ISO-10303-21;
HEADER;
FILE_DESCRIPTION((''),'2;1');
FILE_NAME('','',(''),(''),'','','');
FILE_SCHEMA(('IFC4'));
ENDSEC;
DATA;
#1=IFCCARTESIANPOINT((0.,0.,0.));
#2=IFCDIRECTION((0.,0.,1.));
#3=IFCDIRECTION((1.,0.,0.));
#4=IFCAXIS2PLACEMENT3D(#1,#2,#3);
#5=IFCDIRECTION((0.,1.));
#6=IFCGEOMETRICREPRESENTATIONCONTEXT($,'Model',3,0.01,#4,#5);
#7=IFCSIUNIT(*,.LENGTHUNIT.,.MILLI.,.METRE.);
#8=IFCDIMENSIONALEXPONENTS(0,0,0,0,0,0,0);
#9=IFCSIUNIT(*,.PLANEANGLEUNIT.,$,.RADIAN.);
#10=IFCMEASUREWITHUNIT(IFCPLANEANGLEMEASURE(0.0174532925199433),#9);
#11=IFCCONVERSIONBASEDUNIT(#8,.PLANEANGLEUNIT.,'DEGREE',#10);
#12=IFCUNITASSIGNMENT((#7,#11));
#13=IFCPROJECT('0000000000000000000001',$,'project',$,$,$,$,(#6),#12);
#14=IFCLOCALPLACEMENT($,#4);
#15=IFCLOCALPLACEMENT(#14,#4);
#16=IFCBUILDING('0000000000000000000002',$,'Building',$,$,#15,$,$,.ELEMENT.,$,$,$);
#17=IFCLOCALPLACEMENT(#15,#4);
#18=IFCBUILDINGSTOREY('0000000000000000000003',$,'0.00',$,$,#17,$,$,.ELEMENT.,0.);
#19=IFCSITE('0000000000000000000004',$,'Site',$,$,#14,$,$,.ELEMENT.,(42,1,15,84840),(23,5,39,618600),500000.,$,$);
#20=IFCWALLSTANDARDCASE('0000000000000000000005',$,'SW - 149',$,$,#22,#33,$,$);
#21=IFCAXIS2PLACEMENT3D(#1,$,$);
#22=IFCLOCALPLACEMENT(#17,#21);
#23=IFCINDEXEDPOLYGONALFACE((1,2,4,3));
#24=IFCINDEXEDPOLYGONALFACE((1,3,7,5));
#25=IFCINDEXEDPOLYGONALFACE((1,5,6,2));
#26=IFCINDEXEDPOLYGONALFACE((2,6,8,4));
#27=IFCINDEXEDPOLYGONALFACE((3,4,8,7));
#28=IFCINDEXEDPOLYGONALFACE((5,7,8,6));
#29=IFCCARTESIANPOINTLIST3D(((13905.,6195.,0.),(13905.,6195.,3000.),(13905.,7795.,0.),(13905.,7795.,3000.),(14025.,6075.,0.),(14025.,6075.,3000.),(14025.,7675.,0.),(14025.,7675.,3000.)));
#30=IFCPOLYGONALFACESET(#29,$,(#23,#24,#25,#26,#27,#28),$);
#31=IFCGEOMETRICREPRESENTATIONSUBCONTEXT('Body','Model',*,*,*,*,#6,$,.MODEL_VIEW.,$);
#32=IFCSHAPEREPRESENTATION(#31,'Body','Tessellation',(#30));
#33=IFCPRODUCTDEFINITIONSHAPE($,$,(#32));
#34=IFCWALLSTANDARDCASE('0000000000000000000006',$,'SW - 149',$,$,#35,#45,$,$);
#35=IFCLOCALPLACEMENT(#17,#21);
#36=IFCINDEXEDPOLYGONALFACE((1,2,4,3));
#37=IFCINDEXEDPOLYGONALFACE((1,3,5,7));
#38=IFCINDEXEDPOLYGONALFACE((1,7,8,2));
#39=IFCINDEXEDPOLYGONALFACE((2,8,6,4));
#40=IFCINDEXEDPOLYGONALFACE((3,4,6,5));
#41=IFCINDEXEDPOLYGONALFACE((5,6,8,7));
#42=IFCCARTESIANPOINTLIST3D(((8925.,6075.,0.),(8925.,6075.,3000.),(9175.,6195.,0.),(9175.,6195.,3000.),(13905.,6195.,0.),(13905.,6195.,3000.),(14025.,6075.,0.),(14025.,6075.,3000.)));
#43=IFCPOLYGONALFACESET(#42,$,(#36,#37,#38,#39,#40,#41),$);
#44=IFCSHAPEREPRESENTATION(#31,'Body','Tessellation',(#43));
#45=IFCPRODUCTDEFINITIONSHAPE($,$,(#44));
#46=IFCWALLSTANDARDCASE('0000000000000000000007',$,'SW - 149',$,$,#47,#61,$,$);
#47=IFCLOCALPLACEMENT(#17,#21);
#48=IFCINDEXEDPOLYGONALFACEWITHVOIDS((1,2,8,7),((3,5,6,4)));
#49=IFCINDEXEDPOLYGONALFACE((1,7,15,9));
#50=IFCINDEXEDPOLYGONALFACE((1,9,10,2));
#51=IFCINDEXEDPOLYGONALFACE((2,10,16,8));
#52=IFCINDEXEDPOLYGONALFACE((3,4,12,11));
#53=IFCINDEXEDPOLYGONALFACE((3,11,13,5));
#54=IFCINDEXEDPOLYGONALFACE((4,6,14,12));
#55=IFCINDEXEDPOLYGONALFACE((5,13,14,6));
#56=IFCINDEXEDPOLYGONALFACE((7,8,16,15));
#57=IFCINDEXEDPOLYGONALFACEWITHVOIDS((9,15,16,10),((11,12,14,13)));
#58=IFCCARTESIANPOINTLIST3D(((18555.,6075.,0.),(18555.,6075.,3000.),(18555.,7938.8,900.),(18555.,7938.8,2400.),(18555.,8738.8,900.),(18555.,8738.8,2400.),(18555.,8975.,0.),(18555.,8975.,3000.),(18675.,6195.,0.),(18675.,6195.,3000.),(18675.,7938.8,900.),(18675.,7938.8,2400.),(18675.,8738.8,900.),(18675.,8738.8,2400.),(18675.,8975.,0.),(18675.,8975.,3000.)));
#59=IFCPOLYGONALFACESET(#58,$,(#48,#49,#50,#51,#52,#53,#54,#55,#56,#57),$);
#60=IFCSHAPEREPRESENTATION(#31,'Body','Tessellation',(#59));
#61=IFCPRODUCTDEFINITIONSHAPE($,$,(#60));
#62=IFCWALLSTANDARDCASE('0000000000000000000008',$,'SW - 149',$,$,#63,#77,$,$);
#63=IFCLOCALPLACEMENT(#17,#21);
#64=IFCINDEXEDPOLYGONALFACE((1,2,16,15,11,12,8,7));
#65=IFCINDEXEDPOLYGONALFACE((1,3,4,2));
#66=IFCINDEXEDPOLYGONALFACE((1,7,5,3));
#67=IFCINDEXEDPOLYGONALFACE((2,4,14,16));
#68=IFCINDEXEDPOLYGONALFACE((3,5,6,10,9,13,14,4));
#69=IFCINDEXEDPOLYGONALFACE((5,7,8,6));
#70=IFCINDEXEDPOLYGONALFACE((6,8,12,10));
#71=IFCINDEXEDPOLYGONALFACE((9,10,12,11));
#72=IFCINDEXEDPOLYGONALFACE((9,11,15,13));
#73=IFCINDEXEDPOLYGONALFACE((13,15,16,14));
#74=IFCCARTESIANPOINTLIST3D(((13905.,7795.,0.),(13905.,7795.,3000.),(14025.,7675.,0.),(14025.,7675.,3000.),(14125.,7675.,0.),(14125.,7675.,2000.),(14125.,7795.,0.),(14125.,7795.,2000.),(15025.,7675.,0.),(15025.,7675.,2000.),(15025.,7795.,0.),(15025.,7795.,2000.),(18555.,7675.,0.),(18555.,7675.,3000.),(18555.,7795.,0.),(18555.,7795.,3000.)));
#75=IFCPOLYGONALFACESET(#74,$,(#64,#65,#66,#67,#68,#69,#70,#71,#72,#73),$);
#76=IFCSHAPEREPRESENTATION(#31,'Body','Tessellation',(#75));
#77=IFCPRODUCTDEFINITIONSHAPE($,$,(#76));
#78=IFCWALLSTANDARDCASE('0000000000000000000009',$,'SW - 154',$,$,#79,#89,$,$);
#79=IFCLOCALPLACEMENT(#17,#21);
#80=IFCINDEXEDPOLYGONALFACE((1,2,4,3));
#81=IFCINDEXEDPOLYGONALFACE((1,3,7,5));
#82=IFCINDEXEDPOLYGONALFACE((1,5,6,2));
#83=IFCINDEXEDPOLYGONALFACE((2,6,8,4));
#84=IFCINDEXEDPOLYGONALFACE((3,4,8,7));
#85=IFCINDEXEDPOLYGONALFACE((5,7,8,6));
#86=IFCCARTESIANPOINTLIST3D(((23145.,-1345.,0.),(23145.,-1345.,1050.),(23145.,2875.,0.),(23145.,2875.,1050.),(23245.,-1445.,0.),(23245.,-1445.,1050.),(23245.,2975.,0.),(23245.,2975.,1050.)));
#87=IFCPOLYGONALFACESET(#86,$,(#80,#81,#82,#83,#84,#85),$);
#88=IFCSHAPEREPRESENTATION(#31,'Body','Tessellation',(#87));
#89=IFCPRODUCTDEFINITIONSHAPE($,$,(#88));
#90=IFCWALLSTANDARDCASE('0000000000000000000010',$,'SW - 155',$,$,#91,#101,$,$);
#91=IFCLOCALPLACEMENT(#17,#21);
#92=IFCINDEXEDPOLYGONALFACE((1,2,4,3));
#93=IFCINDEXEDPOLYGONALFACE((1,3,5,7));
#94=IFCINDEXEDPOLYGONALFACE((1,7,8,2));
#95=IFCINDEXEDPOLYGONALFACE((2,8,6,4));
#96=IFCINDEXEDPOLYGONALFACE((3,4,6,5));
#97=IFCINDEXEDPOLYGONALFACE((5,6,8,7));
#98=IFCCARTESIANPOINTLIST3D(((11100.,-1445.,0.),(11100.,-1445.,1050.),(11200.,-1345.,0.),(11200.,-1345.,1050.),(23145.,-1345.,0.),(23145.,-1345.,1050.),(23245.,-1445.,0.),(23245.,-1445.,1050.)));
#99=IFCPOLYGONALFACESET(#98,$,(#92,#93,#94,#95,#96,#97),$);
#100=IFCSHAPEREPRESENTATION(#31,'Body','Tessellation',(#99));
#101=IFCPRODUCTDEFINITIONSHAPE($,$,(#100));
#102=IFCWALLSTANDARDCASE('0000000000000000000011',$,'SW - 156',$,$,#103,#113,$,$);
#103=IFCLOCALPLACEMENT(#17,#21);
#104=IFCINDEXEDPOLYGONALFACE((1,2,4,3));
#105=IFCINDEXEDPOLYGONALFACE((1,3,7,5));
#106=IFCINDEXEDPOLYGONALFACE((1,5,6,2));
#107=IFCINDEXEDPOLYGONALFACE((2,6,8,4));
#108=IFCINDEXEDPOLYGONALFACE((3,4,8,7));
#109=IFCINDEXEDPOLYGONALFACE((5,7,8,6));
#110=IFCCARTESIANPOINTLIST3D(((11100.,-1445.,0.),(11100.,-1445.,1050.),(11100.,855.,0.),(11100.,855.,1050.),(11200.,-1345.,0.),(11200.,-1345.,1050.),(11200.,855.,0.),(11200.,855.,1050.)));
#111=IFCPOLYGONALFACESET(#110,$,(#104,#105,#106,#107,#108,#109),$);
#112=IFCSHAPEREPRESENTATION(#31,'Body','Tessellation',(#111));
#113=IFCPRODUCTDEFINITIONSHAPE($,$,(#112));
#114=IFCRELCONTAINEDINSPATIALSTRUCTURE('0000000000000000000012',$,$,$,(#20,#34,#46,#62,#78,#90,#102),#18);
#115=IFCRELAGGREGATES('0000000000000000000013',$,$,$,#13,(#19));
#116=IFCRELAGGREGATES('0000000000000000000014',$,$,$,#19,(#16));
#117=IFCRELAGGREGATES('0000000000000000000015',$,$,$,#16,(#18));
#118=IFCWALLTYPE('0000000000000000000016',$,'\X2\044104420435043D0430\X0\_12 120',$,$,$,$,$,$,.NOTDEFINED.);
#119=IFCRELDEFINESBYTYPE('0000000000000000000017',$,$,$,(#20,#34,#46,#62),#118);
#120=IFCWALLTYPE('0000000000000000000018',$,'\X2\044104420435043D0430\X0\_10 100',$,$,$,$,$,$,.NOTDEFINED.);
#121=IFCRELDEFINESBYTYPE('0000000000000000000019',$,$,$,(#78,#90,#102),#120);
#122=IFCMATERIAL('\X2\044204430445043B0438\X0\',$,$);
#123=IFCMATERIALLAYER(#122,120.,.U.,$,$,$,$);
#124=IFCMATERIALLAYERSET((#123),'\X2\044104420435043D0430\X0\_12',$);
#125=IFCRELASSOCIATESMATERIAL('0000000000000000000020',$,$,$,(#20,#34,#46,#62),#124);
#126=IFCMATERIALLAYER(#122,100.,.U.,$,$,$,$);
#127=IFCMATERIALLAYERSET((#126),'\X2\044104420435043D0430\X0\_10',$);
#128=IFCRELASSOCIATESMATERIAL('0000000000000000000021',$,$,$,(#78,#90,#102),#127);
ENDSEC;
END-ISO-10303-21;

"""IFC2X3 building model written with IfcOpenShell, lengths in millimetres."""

from ifc_helpers import new_model, entity, si_unit, converted_unit, direction, frame, origin_with_axes, origin_2d_with_axis, place, context, subcontext, project, spatial, polyline, rectangle, outline, extrude, material, layer, layer_set, layer_usage, type_object, element, save


model = new_model("IFC2X3")

# Units and contexts
model_context = context("Model", 3, precision=0.01, world=origin_with_axes(), true_north=direction((0.0, 1.0)))
body_context = subcontext(model_context, "Body", "Model", "MODEL_VIEW")
ifc_project = project(units=[si_unit("LENGTHUNIT", "METRE", prefix="MILLI"), converted_unit("PLANEANGLEUNIT", "DEGREE", entity("IfcPlaneAngleMeasure", 0.0174532925199433), si_unit("PLANEANGLEUNIT", "RADIAN"), dimensions=[0, 0, 0, 0, 0, 0, 0])], contexts=[model_context])

# Site, building, storey
site_placement = place(None, origin_with_axes())
site = spatial("IfcSite", under=ifc_project, at=site_placement, Name="Site", CompositionType="ELEMENT", RefLatitude=(42, 1, 15, 84840), RefLongitude=(23, 5, 39, 618600), RefElevation=500000.0)
building_placement = place(site_placement, origin_with_axes())
building = spatial("IfcBuilding", under=site, at=building_placement, Name="Building", CompositionType="ELEMENT")
storey_placement = place(building_placement, origin_with_axes())
storey = spatial("IfcBuildingStorey", under=building, at=storey_placement, Name="0.00", CompositionType="ELEMENT", Elevation=0.0)

# Shared definitions
ifc_material_1 = material(Name="тухли")

# Shared definitions
ifc_layer_1 = layer(ifc_material_1, 120.0, ventilated="UNKNOWN")
ifc_layer_set_1 = layer_set([ifc_layer_1], Name="стена_12")
wall_type_1 = type_object("IfcWallType", Name="стена_12 120", PredefinedType="NOTDEFINED")

# Walls
ifc_layer_usage_1 = layer_usage(ifc_layer_set_1, "AXIS2", "NEGATIVE", 0.0)
wall_1_placement = place(storey_placement, frame((14025.0, 7675.0, 0.0), z_axis=(0.0, 0.0, 1.0), x_axis=(0.0, -1.0, 0.0)))
element("IfcWallStandardCase", 1, at=wall_1_placement, inside=storey, type_object=wall_type_1, material=ifc_layer_usage_1, Name="SW - 149", context=body_context, shape_type="SweptSolid", body=[
    extrude(outline(polyline([(-120.0, -120.0), (1480.0, -120.0), (1600.0, 0.0), (0.0, 0.0), (-120.0, -120.0)])), origin_with_axes(), (0.0, 0.0, 1.0), 3000.0),
])
ifc_layer_usage_2 = layer_usage(ifc_layer_set_1, "AXIS2", "NEGATIVE", 0.0)
wall_2_placement = place(storey_placement, frame((14025.0, 6075.0, 0.0), z_axis=(0.0, 0.0, 1.0), x_axis=(-1.0, 0.0, 0.0)))
element("IfcWallStandardCase", 2, at=wall_2_placement, inside=storey, type_object=wall_type_1, material=ifc_layer_usage_2, Name="SW - 149", context=body_context, shape_type="SweptSolid", body=[
    extrude(outline(polyline([(120.0, -120.0), (4850.0, -120.0), (5100.0, 0.0), (0.0, 0.0), (120.0, -120.0)])), origin_with_axes(), (0.0, 0.0, 1.0), 3000.0),
])

# Walls, openings
ifc_layer_usage_3 = layer_usage(ifc_layer_set_1, "AXIS2", "NEGATIVE", 0.0)
wall_3_placement = place(storey_placement, frame((18555.0, 6075.0, 0.0), z_axis=(0.0, 0.0, 1.0), x_axis=(0.0, 1.0, 0.0)))
wall_3 = element("IfcWallStandardCase", 3, at=wall_3_placement, inside=storey, type_object=wall_type_1, material=ifc_layer_usage_3, Name="SW - 149", context=body_context, shape_type="SweptSolid", body=[
    extrude(outline(polyline([(120.0, -120.0), (2900.0, -120.0), (2900.0, 0.0), (0.0, 0.0), (120.0, -120.0)])), origin_with_axes(), (0.0, 0.0, 1.0), 3000.0),
])
opening_1_placement = place(wall_3_placement, frame((2263.8, 0.0, 900.0), z_axis=(0.0, 0.0, 1.0), x_axis=(1.0, 0.0, 0.0)))
element("IfcOpeningElement", 4, at=opening_1_placement, cuts=wall_3, context=body_context, shape_type="SweptSolid", body=[
    extrude(rectangle(XDim=800.0, YDim=1500.0, at=origin_2d_with_axis()), frame((0.0, -120.0, 750.0), z_axis=(0.0, 1.0, 0.0), x_axis=(-1.0, 0.0, 0.0)), (0.0, 0.0, 1.0), 360.0),
])
ifc_layer_usage_4 = layer_usage(ifc_layer_set_1, "AXIS2", "NEGATIVE", 0.0)
wall_4_placement = place(storey_placement, frame((18555.0, 7675.0, 0.0), z_axis=(0.0, 0.0, 1.0), x_axis=(-1.0, 0.0, 0.0)))
wall_4 = element("IfcWallStandardCase", 5, at=wall_4_placement, inside=storey, type_object=wall_type_1, material=ifc_layer_usage_4, Name="SW - 149", context=body_context, shape_type="SweptSolid", body=[
    extrude(outline(polyline([(0.0, -120.0), (4650.0, -120.0), (4530.0, 0.0), (0.0, 0.0), (0.0, -120.0)])), origin_with_axes(), (0.0, 0.0, 1.0), 3000.0),
])
opening_2_placement = place(wall_4_placement, frame((3980.0, 0.0, 0.0), z_axis=(0.0, 0.0, 1.0), x_axis=(1.0, 0.0, 0.0)))
element("IfcOpeningElement", 6, at=opening_2_placement, cuts=wall_4, context=body_context, shape_type="SweptSolid", body=[
    extrude(rectangle(XDim=900.0, YDim=2000.0, at=origin_2d_with_axis()), frame((0.0, -120.0, 1000.0), z_axis=(0.0, 1.0, 0.0), x_axis=(1.0, 0.0, 0.0)), (0.0, 0.0, 1.0), 360.0),
])

# Walls
ifc_layer_2 = layer(ifc_material_1, 100.0, ventilated="UNKNOWN")
ifc_layer_set_2 = layer_set([ifc_layer_2], Name="стена_10")
ifc_layer_usage_5 = layer_usage(ifc_layer_set_2, "AXIS2", "NEGATIVE", 0.0)
wall_type_2 = type_object("IfcWallType", Name="стена_10 100", PredefinedType="NOTDEFINED")
wall_5_placement = place(storey_placement, frame((23245.0, 2975.0, 0.0), z_axis=(0.0, 0.0, 1.0), x_axis=(0.0, -1.0, 0.0)))
element("IfcWallStandardCase", 7, at=wall_5_placement, inside=storey, type_object=wall_type_2, material=ifc_layer_usage_5, Name="SW - 154", context=body_context, shape_type="SweptSolid", body=[
    extrude(outline(polyline([(100.0, -100.0), (4320.0, -100.0), (4420.0, 0.0), (0.0, 0.0), (100.0, -100.0)])), origin_with_axes(), (0.0, 0.0, 1.0), 1050.0),
])
ifc_layer_usage_6 = layer_usage(ifc_layer_set_2, "AXIS2", "NEGATIVE", 0.0)
wall_6_placement = place(storey_placement, frame((23245.0, -1445.0, 0.0), z_axis=(0.0, 0.0, 1.0), x_axis=(-1.0, 0.0, 0.0)))
element("IfcWallStandardCase", 8, at=wall_6_placement, inside=storey, type_object=wall_type_2, material=ifc_layer_usage_6, Name="SW - 155", context=body_context, shape_type="SweptSolid", body=[
    extrude(outline(polyline([(100.0, -100.0), (12045.0, -100.0), (12145.0, 0.0), (0.0, 0.0), (100.0, -100.0)])), origin_with_axes(), (0.0, 0.0, 1.0), 1050.0),
])
ifc_layer_usage_7 = layer_usage(ifc_layer_set_2, "AXIS2", "NEGATIVE", 0.0)
wall_7_placement = place(storey_placement, frame((11100.0, -1445.0, 0.0), z_axis=(0.0, 0.0, 1.0), x_axis=(0.0, 1.0, 0.0)))
element("IfcWallStandardCase", 9, at=wall_7_placement, inside=storey, type_object=wall_type_2, material=ifc_layer_usage_7, Name="SW - 156", context=body_context, shape_type="SweptSolid", body=[
    extrude(outline(polyline([(100.0, -100.0), (2300.0, -100.0), (2300.0, 0.0), (0.0, 0.0), (100.0, -100.0)])), origin_with_axes(), (0.0, 0.0, 1.0), 1050.0),
])

save(model, "model.ifc")
